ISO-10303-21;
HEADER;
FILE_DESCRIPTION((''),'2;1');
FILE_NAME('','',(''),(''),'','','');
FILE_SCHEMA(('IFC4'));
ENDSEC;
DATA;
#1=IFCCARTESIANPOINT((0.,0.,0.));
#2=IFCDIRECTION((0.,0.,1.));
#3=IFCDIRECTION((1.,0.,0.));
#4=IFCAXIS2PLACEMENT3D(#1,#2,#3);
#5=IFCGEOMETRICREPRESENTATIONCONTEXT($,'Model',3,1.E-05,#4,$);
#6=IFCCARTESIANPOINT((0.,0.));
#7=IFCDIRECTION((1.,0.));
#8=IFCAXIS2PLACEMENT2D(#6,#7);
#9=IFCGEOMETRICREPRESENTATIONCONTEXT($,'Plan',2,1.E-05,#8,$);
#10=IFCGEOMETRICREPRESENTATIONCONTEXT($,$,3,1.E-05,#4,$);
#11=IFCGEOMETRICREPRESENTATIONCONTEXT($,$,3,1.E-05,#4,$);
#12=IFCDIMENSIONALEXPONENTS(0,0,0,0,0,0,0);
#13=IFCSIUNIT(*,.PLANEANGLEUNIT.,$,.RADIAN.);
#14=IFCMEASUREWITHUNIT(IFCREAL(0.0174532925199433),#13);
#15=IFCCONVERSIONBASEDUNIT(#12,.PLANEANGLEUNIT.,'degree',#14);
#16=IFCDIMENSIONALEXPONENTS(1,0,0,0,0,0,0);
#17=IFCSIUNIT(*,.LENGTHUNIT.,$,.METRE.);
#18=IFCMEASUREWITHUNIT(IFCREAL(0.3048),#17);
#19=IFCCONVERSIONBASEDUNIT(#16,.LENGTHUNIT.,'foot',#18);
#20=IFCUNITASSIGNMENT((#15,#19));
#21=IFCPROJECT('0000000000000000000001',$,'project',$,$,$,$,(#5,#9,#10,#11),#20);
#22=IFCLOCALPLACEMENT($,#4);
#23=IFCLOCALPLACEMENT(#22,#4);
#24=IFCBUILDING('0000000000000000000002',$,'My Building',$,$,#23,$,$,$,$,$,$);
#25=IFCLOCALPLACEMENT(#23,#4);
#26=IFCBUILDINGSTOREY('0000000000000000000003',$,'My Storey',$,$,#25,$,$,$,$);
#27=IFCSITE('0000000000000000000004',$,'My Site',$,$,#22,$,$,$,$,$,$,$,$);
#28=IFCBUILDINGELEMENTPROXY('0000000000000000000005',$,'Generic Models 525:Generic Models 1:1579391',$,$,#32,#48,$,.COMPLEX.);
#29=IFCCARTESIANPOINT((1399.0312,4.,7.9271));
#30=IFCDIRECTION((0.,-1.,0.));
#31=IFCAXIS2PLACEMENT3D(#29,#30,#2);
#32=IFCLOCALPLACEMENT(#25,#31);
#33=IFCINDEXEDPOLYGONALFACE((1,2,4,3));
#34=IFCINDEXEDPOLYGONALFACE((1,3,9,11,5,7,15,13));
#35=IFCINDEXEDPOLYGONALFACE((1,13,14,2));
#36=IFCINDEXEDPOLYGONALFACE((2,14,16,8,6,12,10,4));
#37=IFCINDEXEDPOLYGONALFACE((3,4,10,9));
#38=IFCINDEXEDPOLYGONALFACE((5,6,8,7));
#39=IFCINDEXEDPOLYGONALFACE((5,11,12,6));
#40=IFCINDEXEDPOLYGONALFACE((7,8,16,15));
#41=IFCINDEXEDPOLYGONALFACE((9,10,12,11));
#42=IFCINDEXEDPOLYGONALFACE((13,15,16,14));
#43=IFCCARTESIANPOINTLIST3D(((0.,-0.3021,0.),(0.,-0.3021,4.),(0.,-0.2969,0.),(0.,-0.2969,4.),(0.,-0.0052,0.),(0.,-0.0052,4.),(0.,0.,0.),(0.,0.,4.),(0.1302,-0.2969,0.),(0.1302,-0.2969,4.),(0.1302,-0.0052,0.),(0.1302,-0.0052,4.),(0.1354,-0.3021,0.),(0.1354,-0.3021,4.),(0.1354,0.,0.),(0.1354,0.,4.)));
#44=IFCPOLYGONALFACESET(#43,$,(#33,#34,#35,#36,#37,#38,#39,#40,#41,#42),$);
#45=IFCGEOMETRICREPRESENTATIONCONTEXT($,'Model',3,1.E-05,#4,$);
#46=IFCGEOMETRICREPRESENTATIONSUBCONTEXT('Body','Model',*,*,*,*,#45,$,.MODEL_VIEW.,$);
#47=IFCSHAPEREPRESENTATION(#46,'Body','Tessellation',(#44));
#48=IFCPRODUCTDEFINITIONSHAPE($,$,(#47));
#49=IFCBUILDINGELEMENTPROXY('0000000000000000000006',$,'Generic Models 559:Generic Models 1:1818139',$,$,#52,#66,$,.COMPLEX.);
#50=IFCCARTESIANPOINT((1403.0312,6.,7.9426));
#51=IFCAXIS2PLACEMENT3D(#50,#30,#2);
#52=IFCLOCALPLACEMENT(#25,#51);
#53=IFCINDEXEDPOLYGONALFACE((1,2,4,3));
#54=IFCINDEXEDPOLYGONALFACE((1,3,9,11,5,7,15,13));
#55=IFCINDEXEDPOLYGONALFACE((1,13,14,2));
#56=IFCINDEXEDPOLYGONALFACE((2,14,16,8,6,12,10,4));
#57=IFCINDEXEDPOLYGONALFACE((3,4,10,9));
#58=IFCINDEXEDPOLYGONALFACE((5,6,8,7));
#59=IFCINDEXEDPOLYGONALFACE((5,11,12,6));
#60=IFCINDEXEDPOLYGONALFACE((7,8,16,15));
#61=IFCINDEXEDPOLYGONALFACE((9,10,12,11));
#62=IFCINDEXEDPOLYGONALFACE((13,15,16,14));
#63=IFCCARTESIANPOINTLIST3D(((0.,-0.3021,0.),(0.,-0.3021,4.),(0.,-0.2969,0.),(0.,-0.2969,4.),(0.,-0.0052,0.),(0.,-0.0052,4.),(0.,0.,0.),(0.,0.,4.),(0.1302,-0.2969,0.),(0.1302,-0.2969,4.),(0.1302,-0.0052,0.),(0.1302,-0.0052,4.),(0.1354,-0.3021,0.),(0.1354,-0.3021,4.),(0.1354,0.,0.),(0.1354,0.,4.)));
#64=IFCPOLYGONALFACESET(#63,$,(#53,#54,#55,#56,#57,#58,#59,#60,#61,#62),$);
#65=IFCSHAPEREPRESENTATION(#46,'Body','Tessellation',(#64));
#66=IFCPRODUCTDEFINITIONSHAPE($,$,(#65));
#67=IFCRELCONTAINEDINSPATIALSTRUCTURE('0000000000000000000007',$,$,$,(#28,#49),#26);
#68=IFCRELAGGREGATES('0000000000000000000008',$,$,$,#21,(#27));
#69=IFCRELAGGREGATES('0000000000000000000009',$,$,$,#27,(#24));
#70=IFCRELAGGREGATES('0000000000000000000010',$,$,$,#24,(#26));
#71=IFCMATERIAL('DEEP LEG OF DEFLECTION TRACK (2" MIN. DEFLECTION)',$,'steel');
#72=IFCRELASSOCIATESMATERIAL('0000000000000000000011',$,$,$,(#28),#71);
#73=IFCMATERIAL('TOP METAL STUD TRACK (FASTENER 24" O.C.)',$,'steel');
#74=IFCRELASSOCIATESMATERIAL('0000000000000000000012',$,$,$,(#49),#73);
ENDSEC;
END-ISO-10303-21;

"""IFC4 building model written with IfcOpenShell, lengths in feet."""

from ifc_helpers import new_model, entity, si_unit, converted_unit, frame, origin_with_axes, origin_2d_with_axis, place, context, subcontext, project, spatial, polyline, outline, extrude, material, element, save


model = new_model("IFC4")

# Units and contexts
model_context_1 = context("Model", 3, precision=1e-05, world=origin_with_axes())
plan_context = context("Plan", 2, precision=1e-05, world=origin_2d_with_axis())
model_context_2 = context("Model", 3, precision=1e-05, world=origin_with_axes())
context_of_model_1 = context(None, 3, precision=1e-05, world=origin_with_axes())
context_of_model_2 = context(None, 3, precision=1e-05, world=origin_with_axes())
body_context = subcontext(model_context_2, "Body", "Model", "MODEL_VIEW")
ifc_project = project(units=[converted_unit("PLANEANGLEUNIT", "degree", entity("IfcReal", 0.0174532925199433), si_unit("PLANEANGLEUNIT", "RADIAN"), dimensions=[0, 0, 0, 0, 0, 0, 0]), converted_unit("LENGTHUNIT", "foot", entity("IfcReal", 0.3048), si_unit("LENGTHUNIT", "METRE"), dimensions=[1, 0, 0, 0, 0, 0, 0])], contexts=[model_context_1, plan_context, context_of_model_1, context_of_model_2])

# Site, building, storey
site_placement = place(None, origin_with_axes())
site = spatial("IfcSite", under=ifc_project, at=site_placement, Name="My Site")
building_placement = place(site_placement, origin_with_axes())
building = spatial("IfcBuilding", under=site, at=building_placement, Name="My Building")
storey_placement = place(building_placement, origin_with_axes())
storey = spatial("IfcBuildingStorey", under=building, at=storey_placement, Name="My Storey")

# Building element proxies
ifc_material_1 = material(Name="DEEP LEG OF DEFLECTION TRACK (2\" MIN. DEFLECTION)", Category="steel")
proxy_1_placement = place(storey_placement, frame((1399.0312, 4.0, 7.9271), z_axis=(0.0, -1.0, 0.0), x_axis=(0.0, 0.0, 1.0)))
element("IfcBuildingElementProxy", 1, at=proxy_1_placement, inside=storey, material=ifc_material_1, Name="Generic Models 525:Generic Models 1:1579391", PredefinedType="COMPLEX", context=body_context, shape_type="SweptSolid", body=[
    extrude(outline(polyline([(-0.151, -0.069), (0.151, -0.069), (0.151, 0.0664), (0.1458, 0.0664), (0.1458, -0.0638), (-0.1458, -0.0638), (-0.1458, 0.0664), (-0.151, 0.0664), (-0.151, -0.069)])), frame((0.0664, -0.151, 0.0), z_axis=(0.0, 0.0, -1.0), x_axis=(0.0, -1.0, 0.0)), (0.0, 0.0, -1.0), 4.0),
])
ifc_material_2 = material(Name="TOP METAL STUD TRACK (FASTENER 24\" O.C.)", Category="steel")
proxy_2_placement = place(storey_placement, frame((1403.0312, 6.0, 7.9426), z_axis=(0.0, -1.0, 0.0), x_axis=(0.0, 0.0, 1.0)))
element("IfcBuildingElementProxy", 2, at=proxy_2_placement, inside=storey, material=ifc_material_2, Name="Generic Models 559:Generic Models 1:1818139", PredefinedType="COMPLEX", context=body_context, shape_type="SweptSolid", body=[
    extrude(outline(polyline([(-0.069, -0.151), (0.0664, -0.151), (0.0664, -0.1458), (-0.0638, -0.1458), (-0.0638, 0.1458), (0.0664, 0.1458), (0.0664, 0.151), (-0.069, 0.151), (-0.069, -0.151)])), frame((0.0664, -0.151, 0.0), z_axis=(0.0, 0.0, -1.0), x_axis=(-1.0, 0.0, 0.0)), (0.0, 0.0, -1.0), 4.0),
])

save(model, "model.ifc")
